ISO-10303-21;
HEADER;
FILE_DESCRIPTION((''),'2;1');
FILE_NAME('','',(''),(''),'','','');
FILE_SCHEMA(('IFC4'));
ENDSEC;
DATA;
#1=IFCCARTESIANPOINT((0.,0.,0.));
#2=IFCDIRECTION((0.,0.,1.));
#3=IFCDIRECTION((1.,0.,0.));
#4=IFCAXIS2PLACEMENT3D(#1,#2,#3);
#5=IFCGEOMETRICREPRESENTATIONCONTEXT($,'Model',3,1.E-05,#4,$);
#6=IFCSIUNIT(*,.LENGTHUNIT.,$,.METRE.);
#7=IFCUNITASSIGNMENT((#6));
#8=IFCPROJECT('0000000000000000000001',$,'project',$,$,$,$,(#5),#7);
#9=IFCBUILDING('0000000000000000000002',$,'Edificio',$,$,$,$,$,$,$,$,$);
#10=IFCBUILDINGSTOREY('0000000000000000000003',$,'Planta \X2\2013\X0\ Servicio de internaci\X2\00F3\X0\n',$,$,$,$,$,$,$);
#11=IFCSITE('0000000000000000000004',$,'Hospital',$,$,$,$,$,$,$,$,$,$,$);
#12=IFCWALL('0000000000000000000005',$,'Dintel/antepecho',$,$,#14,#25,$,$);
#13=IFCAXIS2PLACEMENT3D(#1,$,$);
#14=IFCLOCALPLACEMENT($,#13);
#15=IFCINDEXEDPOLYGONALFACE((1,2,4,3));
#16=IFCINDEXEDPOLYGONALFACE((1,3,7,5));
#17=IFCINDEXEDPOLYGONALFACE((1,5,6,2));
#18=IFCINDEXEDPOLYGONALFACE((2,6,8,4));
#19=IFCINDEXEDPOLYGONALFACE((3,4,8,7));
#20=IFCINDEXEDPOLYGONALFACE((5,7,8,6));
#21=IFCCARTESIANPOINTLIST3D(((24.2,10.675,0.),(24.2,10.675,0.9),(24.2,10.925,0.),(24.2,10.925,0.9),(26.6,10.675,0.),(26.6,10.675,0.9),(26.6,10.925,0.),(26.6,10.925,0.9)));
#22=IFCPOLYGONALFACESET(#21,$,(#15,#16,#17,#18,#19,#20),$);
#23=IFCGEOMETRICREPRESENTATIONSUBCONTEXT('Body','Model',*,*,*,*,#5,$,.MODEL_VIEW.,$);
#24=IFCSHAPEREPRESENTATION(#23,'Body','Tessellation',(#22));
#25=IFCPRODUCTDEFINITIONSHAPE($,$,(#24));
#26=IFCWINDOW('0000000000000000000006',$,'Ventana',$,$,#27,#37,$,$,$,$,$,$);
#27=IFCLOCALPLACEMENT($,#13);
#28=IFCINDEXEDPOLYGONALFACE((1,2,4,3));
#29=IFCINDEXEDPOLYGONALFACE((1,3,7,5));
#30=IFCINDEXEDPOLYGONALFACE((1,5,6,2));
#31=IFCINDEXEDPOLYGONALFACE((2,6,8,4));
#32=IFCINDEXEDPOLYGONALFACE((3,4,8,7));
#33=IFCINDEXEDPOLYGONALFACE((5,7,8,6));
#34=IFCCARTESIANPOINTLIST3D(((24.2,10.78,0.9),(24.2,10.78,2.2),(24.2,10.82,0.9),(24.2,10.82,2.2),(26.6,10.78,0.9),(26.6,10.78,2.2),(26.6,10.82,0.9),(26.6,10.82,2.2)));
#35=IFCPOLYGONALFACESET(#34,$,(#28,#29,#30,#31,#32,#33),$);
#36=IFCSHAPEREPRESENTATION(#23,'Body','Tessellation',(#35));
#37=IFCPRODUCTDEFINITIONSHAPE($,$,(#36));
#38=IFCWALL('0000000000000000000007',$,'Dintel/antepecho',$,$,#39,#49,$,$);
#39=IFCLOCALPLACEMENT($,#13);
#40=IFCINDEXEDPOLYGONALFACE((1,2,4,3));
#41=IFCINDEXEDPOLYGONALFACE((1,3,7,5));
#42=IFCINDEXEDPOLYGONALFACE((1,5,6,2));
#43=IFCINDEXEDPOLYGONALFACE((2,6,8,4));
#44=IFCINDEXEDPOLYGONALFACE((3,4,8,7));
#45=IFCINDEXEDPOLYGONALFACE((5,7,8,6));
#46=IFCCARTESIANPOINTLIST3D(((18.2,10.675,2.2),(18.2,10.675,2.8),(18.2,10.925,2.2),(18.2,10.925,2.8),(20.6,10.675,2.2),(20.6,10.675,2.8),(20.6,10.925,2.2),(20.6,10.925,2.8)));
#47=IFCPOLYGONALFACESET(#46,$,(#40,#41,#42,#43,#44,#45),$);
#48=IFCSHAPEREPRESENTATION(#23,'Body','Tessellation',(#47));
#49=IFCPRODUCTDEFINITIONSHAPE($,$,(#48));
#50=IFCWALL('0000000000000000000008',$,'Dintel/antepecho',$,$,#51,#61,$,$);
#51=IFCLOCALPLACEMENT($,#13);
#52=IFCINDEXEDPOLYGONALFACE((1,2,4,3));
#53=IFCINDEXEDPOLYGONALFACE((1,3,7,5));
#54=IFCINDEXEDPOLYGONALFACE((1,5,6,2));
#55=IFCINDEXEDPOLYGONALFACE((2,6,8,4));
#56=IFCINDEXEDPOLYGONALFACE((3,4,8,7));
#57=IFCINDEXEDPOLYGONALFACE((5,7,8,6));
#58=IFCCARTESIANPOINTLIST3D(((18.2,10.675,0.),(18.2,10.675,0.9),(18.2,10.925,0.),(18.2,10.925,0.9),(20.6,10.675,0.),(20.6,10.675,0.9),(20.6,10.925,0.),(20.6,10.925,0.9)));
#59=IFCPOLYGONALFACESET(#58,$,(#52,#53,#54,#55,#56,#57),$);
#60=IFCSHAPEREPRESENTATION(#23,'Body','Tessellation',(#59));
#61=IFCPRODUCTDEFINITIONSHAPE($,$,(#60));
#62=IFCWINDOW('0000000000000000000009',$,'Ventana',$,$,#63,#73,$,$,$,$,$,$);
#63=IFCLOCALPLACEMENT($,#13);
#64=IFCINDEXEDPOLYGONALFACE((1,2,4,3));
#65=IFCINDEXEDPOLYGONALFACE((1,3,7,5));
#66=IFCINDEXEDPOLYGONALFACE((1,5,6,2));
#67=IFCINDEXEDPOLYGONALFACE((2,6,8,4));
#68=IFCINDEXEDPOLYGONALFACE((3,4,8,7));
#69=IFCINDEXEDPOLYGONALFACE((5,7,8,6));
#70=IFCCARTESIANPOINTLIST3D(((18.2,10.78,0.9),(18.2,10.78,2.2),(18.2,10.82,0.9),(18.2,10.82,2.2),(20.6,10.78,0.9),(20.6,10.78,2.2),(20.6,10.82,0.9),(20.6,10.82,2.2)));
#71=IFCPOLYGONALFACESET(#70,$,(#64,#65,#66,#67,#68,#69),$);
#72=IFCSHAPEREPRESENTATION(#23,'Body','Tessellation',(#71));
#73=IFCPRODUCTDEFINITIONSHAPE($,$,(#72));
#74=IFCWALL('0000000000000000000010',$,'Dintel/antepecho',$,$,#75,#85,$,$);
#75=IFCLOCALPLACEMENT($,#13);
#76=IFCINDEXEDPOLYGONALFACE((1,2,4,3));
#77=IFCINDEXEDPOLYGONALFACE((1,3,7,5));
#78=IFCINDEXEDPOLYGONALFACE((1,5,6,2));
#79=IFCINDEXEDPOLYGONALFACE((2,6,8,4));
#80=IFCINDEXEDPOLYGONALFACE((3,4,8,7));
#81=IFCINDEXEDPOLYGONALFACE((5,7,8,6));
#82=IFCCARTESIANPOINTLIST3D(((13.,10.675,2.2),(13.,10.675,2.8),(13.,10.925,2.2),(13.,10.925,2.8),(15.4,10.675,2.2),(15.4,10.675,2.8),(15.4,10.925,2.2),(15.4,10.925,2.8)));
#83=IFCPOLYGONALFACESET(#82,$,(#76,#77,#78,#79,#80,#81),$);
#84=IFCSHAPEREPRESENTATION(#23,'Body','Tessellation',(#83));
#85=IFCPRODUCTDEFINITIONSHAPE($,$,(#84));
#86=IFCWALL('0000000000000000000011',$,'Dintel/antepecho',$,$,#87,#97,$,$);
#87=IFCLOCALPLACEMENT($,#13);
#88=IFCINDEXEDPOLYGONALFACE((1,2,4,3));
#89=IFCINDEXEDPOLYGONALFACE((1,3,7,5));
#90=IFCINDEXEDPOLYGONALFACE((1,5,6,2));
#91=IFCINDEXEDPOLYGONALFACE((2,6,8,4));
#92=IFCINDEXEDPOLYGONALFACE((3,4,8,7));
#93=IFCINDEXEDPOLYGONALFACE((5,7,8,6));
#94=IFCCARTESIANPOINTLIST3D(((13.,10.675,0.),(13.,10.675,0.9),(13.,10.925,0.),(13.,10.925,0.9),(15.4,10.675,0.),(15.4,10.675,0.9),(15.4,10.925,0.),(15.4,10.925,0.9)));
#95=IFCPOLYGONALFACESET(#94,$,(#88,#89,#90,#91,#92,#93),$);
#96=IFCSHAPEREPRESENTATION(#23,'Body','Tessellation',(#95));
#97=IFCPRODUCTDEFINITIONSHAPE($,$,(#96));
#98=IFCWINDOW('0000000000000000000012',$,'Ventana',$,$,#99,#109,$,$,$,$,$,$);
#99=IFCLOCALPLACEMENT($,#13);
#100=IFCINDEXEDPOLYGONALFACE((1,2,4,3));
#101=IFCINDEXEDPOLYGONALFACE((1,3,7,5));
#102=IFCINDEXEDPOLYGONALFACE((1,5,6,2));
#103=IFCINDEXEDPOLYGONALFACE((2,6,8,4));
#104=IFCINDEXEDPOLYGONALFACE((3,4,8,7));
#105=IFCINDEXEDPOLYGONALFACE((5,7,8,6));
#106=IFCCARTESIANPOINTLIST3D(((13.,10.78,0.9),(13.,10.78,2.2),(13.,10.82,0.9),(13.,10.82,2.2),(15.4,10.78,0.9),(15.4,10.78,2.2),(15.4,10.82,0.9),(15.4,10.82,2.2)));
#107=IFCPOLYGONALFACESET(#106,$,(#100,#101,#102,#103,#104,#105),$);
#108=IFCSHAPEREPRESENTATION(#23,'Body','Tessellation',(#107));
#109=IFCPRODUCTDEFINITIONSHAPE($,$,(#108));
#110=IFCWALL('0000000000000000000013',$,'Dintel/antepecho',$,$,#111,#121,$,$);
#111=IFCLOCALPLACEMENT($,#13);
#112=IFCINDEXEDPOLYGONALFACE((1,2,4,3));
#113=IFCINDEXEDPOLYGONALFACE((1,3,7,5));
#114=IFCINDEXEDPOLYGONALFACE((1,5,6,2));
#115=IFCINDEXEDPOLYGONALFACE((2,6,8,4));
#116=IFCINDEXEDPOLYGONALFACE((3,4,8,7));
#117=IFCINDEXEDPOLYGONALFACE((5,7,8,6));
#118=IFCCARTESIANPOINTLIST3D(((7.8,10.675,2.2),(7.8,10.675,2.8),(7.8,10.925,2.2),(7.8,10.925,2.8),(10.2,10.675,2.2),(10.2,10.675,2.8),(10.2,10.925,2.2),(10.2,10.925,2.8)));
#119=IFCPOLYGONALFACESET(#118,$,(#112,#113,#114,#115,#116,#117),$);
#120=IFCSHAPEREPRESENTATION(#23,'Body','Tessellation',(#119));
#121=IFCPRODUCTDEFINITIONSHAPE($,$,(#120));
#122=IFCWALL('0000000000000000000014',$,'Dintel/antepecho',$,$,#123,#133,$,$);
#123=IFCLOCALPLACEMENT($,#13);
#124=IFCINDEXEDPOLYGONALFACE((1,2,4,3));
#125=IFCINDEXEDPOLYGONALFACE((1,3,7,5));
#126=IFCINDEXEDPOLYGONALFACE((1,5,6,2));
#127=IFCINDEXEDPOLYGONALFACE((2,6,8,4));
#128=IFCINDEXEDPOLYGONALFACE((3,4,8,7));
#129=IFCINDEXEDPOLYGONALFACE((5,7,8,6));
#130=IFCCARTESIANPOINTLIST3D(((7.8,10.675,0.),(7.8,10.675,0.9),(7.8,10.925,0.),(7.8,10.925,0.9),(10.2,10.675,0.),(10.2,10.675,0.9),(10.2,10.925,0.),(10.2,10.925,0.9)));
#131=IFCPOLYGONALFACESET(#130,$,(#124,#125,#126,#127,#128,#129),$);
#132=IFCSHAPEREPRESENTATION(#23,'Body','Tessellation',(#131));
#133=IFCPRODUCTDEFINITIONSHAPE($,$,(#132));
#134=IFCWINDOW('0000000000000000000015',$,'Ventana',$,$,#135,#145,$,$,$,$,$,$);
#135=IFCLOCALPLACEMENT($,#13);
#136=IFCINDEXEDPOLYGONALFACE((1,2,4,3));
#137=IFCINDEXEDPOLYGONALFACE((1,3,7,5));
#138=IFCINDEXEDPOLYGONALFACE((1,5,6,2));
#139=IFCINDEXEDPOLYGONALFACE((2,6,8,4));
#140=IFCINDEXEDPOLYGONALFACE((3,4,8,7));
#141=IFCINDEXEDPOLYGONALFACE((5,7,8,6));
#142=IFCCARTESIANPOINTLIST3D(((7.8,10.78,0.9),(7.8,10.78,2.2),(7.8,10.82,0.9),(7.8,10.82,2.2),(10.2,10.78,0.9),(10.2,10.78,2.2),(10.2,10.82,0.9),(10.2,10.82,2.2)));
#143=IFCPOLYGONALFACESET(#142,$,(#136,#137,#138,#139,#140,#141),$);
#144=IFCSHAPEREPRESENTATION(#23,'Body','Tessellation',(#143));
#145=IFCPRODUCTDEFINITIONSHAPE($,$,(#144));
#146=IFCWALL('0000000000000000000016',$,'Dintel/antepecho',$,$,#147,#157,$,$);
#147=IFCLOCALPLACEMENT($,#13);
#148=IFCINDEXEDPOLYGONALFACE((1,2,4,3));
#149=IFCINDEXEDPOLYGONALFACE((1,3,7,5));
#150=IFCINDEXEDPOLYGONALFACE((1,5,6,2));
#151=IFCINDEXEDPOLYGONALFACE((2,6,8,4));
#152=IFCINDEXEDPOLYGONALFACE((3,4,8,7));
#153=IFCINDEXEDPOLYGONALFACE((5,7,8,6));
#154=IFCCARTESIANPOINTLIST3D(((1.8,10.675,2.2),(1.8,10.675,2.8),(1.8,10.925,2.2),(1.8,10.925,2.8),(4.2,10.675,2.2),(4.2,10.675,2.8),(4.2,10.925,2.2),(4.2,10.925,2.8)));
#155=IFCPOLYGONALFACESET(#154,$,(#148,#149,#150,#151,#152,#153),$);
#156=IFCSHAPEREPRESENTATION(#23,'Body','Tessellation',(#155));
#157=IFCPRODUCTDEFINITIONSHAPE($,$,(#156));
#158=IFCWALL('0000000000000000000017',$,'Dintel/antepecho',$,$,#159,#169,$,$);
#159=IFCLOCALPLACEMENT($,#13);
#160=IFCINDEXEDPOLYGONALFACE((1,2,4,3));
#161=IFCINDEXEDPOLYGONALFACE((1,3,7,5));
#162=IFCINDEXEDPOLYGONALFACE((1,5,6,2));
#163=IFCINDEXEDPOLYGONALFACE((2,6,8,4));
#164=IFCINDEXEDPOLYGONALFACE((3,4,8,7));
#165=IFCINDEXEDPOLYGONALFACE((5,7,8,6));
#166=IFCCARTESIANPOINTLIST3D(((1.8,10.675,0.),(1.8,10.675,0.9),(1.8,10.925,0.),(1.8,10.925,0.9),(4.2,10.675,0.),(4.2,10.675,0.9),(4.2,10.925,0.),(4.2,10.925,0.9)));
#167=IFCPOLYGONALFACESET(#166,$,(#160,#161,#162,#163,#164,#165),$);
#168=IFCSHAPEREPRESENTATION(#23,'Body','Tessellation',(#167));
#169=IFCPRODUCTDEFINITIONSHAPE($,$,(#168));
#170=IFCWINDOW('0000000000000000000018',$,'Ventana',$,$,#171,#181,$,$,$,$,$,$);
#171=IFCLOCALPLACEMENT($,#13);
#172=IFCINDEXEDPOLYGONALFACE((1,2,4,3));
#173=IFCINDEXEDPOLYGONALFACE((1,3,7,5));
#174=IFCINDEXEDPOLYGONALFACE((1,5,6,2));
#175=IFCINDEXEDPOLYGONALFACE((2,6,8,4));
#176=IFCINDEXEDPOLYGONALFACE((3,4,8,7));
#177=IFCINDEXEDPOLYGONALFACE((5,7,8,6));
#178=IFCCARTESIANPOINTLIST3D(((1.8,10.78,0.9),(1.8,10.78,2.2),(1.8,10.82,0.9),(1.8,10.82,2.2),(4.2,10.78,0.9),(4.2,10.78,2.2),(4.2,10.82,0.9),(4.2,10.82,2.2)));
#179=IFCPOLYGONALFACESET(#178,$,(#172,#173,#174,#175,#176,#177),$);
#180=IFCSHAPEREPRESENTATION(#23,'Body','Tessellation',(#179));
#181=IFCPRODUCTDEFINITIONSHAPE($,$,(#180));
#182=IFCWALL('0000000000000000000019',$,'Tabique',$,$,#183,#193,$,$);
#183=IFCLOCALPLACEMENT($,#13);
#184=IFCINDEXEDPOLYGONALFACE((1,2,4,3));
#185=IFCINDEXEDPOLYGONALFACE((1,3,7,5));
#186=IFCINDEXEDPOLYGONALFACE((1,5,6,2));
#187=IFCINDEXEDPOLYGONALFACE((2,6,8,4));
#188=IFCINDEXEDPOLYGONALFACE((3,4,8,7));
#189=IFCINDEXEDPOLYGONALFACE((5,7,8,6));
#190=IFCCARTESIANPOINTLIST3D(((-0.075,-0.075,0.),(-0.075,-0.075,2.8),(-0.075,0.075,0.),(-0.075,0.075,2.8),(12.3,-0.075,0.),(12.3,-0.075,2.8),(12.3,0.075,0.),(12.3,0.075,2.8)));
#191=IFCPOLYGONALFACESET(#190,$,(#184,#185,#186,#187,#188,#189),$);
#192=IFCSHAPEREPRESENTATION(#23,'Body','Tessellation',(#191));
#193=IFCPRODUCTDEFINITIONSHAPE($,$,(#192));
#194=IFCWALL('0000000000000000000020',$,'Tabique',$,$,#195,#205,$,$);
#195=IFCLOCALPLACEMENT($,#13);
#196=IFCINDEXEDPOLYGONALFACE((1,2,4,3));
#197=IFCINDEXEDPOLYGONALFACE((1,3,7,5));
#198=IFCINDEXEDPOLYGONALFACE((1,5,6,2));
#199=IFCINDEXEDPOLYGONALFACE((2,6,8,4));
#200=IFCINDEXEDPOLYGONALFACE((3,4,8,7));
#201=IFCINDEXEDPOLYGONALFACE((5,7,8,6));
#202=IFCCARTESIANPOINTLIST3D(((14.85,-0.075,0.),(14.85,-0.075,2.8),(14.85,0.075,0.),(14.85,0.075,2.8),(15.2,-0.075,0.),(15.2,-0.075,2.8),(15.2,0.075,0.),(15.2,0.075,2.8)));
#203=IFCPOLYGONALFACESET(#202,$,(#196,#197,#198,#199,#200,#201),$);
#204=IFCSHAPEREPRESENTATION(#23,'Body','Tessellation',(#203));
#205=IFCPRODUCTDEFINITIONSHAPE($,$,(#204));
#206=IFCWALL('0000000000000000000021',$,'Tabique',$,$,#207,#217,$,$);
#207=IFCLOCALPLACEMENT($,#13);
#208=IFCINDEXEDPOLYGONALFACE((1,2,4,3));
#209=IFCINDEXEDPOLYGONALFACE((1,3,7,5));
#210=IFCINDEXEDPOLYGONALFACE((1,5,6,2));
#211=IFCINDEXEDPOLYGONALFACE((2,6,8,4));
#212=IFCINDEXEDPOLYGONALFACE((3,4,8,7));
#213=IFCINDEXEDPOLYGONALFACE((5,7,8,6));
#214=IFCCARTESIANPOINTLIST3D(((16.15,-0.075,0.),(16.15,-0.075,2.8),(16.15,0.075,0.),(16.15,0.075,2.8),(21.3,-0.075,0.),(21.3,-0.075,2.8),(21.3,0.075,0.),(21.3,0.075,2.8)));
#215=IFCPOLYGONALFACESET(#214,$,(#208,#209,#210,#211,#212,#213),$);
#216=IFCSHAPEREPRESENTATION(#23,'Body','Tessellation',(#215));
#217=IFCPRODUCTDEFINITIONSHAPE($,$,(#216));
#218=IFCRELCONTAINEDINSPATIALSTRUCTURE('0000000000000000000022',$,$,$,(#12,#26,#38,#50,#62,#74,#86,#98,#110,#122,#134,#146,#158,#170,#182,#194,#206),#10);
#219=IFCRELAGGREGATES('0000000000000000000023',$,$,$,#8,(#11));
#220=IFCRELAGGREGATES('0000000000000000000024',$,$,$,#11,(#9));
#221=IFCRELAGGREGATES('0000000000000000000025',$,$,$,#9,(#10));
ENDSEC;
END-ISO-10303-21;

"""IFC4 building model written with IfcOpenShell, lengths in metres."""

from ifc_helpers import new_model, si_unit, frame, origin_with_axes, context, subcontext, project, spatial, line, indexed_curve, outline, extrude, element, save


model = new_model("IFC4")

# Units and contexts
model_context = context("Model", 3, precision=1e-05, world=origin_with_axes())
body_context = subcontext(model_context, "Body", "Model", "MODEL_VIEW")
ifc_project = project(units=[si_unit("LENGTHUNIT", "METRE")], contexts=[model_context])

# Site, building, storey
site = spatial("IfcSite", under=ifc_project, Name="Hospital")
building = spatial("IfcBuilding", under=site, Name="Edificio")
storey = spatial("IfcBuildingStorey", under=building, Name="Planta – Servicio de internación")

# Wall
element("IfcWall", 1, inside=storey, Name="Dintel/antepecho", context=body_context, shape_type="SweptSolid", body=[
    extrude(outline(indexed_curve([(0.0, 0.0), (2.4, 0.0), (2.4, 0.25), (0.0, 0.25)], segments=[line(1, 2, 3, 4, 1)])), frame((24.2, 10.675, 0.0), z_axis=(0.0, 0.0, 1.0), x_axis=(1.0, 0.0, 0.0)), (0.0, 0.0, 1.0), 0.9),
])

# Window
element("IfcWindow", 2, inside=storey, Name="Ventana", context=body_context, shape_type="SweptSolid", body=[
    extrude(outline(indexed_curve([(0.0, 0.0), (2.4, 0.0), (2.4, 0.04), (0.0, 0.04)], segments=[line(1, 2, 3, 4, 1)])), frame((24.2, 10.78, 0.9), z_axis=(0.0, 0.0, 1.0), x_axis=(1.0, 0.0, 0.0)), (0.0, 0.0, 1.0), 1.3),
])

# Walls
element("IfcWall", 3, inside=storey, Name="Dintel/antepecho", context=body_context, shape_type="SweptSolid", body=[
    extrude(outline(indexed_curve([(0.0, 0.0), (2.4, 0.0), (2.4, 0.25), (0.0, 0.25)], segments=[line(1, 2, 3, 4, 1)])), frame((18.2, 10.675, 2.2), z_axis=(0.0, 0.0, 1.0), x_axis=(1.0, 0.0, 0.0)), (0.0, 0.0, 1.0), 0.6),
])
element("IfcWall", 4, inside=storey, Name="Dintel/antepecho", context=body_context, shape_type="SweptSolid", body=[
    extrude(outline(indexed_curve([(0.0, 0.0), (2.4, 0.0), (2.4, 0.25), (0.0, 0.25)], segments=[line(1, 2, 3, 4, 1)])), frame((18.2, 10.675, 0.0), z_axis=(0.0, 0.0, 1.0), x_axis=(1.0, 0.0, 0.0)), (0.0, 0.0, 1.0), 0.9),
])

# Window
element("IfcWindow", 5, inside=storey, Name="Ventana", context=body_context, shape_type="SweptSolid", body=[
    extrude(outline(indexed_curve([(0.0, 0.0), (2.4, 0.0), (2.4, 0.04), (0.0, 0.04)], segments=[line(1, 2, 3, 4, 1)])), frame((18.2, 10.78, 0.9), z_axis=(0.0, 0.0, 1.0), x_axis=(1.0, 0.0, 0.0)), (0.0, 0.0, 1.0), 1.3),
])

# Walls
element("IfcWall", 6, inside=storey, Name="Dintel/antepecho", context=body_context, shape_type="SweptSolid", body=[
    extrude(outline(indexed_curve([(0.0, 0.0), (2.4, 0.0), (2.4, 0.25), (0.0, 0.25)], segments=[line(1, 2, 3, 4, 1)])), frame((13.0, 10.675, 2.2), z_axis=(0.0, 0.0, 1.0), x_axis=(1.0, 0.0, 0.0)), (0.0, 0.0, 1.0), 0.6),
])
element("IfcWall", 7, inside=storey, Name="Dintel/antepecho", context=body_context, shape_type="SweptSolid", body=[
    extrude(outline(indexed_curve([(0.0, 0.0), (2.4, 0.0), (2.4, 0.25), (0.0, 0.25)], segments=[line(1, 2, 3, 4, 1)])), frame((13.0, 10.675, 0.0), z_axis=(0.0, 0.0, 1.0), x_axis=(1.0, 0.0, 0.0)), (0.0, 0.0, 1.0), 0.9),
])

# Window
element("IfcWindow", 8, inside=storey, Name="Ventana", context=body_context, shape_type="SweptSolid", body=[
    extrude(outline(indexed_curve([(0.0, 0.0), (2.4, 0.0), (2.4, 0.04), (0.0, 0.04)], segments=[line(1, 2, 3, 4, 1)])), frame((13.0, 10.78, 0.9), z_axis=(0.0, 0.0, 1.0), x_axis=(1.0, 0.0, 0.0)), (0.0, 0.0, 1.0), 1.3),
])

# Walls
element("IfcWall", 9, inside=storey, Name="Dintel/antepecho", context=body_context, shape_type="SweptSolid", body=[
    extrude(outline(indexed_curve([(0.0, 0.0), (2.4, 0.0), (2.4, 0.25), (0.0, 0.25)], segments=[line(1, 2, 3, 4, 1)])), frame((7.8, 10.675, 2.2), z_axis=(0.0, 0.0, 1.0), x_axis=(1.0, 0.0, 0.0)), (0.0, 0.0, 1.0), 0.6),
])
element("IfcWall", 10, inside=storey, Name="Dintel/antepecho", context=body_context, shape_type="SweptSolid", body=[
    extrude(outline(indexed_curve([(0.0, 0.0), (2.4, 0.0), (2.4, 0.25), (0.0, 0.25)], segments=[line(1, 2, 3, 4, 1)])), frame((7.8, 10.675, 0.0), z_axis=(0.0, 0.0, 1.0), x_axis=(1.0, 0.0, 0.0)), (0.0, 0.0, 1.0), 0.9),
])

# Window
element("IfcWindow", 11, inside=storey, Name="Ventana", context=body_context, shape_type="SweptSolid", body=[
    extrude(outline(indexed_curve([(0.0, 0.0), (2.4, 0.0), (2.4, 0.04), (0.0, 0.04)], segments=[line(1, 2, 3, 4, 1)])), frame((7.8, 10.78, 0.9), z_axis=(0.0, 0.0, 1.0), x_axis=(1.0, 0.0, 0.0)), (0.0, 0.0, 1.0), 1.3),
])

# Walls
element("IfcWall", 12, inside=storey, Name="Dintel/antepecho", context=body_context, shape_type="SweptSolid", body=[
    extrude(outline(indexed_curve([(0.0, 0.0), (2.4, 0.0), (2.4, 0.25), (0.0, 0.25)], segments=[line(1, 2, 3, 4, 1)])), frame((1.8, 10.675, 2.2), z_axis=(0.0, 0.0, 1.0), x_axis=(1.0, 0.0, 0.0)), (0.0, 0.0, 1.0), 0.6),
])
element("IfcWall", 13, inside=storey, Name="Dintel/antepecho", context=body_context, shape_type="SweptSolid", body=[
    extrude(outline(indexed_curve([(0.0, 0.0), (2.4, 0.0), (2.4, 0.25), (0.0, 0.25)], segments=[line(1, 2, 3, 4, 1)])), frame((1.8, 10.675, 0.0), z_axis=(0.0, 0.0, 1.0), x_axis=(1.0, 0.0, 0.0)), (0.0, 0.0, 1.0), 0.9),
])

# Window
element("IfcWindow", 14, inside=storey, Name="Ventana", context=body_context, shape_type="SweptSolid", body=[
    extrude(outline(indexed_curve([(0.0, 0.0), (2.4, 0.0), (2.4, 0.04), (0.0, 0.04)], segments=[line(1, 2, 3, 4, 1)])), frame((1.8, 10.78, 0.9), z_axis=(0.0, 0.0, 1.0), x_axis=(1.0, 0.0, 0.0)), (0.0, 0.0, 1.0), 1.3),
])

# Walls
element("IfcWall", 15, inside=storey, Name="Tabique", context=body_context, shape_type="SweptSolid", body=[
    extrude(outline(indexed_curve([(0.0, 0.0), (12.375, 0.0), (12.375, 0.15), (0.0, 0.15)], segments=[line(1, 2, 3, 4, 1)])), frame((-0.075, -0.075, 0.0), z_axis=(0.0, 0.0, 1.0), x_axis=(1.0, 0.0, 0.0)), (0.0, 0.0, 1.0), 2.8),
])
element("IfcWall", 16, inside=storey, Name="Tabique", context=body_context, shape_type="SweptSolid", body=[
    extrude(outline(indexed_curve([(0.0, 0.0), (0.35, 0.0), (0.35, 0.15), (0.0, 0.15)], segments=[line(1, 2, 3, 4, 1)])), frame((14.85, -0.075, 0.0), z_axis=(0.0, 0.0, 1.0), x_axis=(1.0, 0.0, 0.0)), (0.0, 0.0, 1.0), 2.8),
])
element("IfcWall", 17, inside=storey, Name="Tabique", context=body_context, shape_type="SweptSolid", body=[
    extrude(outline(indexed_curve([(0.0, 0.0), (5.15, 0.0), (5.15, 0.15), (0.0, 0.15)], segments=[line(1, 2, 3, 4, 1)])), frame((16.15, -0.075, 0.0), z_axis=(0.0, 0.0, 1.0), x_axis=(1.0, 0.0, 0.0)), (0.0, 0.0, 1.0), 2.8),
])

save(model, "model.ifc")
